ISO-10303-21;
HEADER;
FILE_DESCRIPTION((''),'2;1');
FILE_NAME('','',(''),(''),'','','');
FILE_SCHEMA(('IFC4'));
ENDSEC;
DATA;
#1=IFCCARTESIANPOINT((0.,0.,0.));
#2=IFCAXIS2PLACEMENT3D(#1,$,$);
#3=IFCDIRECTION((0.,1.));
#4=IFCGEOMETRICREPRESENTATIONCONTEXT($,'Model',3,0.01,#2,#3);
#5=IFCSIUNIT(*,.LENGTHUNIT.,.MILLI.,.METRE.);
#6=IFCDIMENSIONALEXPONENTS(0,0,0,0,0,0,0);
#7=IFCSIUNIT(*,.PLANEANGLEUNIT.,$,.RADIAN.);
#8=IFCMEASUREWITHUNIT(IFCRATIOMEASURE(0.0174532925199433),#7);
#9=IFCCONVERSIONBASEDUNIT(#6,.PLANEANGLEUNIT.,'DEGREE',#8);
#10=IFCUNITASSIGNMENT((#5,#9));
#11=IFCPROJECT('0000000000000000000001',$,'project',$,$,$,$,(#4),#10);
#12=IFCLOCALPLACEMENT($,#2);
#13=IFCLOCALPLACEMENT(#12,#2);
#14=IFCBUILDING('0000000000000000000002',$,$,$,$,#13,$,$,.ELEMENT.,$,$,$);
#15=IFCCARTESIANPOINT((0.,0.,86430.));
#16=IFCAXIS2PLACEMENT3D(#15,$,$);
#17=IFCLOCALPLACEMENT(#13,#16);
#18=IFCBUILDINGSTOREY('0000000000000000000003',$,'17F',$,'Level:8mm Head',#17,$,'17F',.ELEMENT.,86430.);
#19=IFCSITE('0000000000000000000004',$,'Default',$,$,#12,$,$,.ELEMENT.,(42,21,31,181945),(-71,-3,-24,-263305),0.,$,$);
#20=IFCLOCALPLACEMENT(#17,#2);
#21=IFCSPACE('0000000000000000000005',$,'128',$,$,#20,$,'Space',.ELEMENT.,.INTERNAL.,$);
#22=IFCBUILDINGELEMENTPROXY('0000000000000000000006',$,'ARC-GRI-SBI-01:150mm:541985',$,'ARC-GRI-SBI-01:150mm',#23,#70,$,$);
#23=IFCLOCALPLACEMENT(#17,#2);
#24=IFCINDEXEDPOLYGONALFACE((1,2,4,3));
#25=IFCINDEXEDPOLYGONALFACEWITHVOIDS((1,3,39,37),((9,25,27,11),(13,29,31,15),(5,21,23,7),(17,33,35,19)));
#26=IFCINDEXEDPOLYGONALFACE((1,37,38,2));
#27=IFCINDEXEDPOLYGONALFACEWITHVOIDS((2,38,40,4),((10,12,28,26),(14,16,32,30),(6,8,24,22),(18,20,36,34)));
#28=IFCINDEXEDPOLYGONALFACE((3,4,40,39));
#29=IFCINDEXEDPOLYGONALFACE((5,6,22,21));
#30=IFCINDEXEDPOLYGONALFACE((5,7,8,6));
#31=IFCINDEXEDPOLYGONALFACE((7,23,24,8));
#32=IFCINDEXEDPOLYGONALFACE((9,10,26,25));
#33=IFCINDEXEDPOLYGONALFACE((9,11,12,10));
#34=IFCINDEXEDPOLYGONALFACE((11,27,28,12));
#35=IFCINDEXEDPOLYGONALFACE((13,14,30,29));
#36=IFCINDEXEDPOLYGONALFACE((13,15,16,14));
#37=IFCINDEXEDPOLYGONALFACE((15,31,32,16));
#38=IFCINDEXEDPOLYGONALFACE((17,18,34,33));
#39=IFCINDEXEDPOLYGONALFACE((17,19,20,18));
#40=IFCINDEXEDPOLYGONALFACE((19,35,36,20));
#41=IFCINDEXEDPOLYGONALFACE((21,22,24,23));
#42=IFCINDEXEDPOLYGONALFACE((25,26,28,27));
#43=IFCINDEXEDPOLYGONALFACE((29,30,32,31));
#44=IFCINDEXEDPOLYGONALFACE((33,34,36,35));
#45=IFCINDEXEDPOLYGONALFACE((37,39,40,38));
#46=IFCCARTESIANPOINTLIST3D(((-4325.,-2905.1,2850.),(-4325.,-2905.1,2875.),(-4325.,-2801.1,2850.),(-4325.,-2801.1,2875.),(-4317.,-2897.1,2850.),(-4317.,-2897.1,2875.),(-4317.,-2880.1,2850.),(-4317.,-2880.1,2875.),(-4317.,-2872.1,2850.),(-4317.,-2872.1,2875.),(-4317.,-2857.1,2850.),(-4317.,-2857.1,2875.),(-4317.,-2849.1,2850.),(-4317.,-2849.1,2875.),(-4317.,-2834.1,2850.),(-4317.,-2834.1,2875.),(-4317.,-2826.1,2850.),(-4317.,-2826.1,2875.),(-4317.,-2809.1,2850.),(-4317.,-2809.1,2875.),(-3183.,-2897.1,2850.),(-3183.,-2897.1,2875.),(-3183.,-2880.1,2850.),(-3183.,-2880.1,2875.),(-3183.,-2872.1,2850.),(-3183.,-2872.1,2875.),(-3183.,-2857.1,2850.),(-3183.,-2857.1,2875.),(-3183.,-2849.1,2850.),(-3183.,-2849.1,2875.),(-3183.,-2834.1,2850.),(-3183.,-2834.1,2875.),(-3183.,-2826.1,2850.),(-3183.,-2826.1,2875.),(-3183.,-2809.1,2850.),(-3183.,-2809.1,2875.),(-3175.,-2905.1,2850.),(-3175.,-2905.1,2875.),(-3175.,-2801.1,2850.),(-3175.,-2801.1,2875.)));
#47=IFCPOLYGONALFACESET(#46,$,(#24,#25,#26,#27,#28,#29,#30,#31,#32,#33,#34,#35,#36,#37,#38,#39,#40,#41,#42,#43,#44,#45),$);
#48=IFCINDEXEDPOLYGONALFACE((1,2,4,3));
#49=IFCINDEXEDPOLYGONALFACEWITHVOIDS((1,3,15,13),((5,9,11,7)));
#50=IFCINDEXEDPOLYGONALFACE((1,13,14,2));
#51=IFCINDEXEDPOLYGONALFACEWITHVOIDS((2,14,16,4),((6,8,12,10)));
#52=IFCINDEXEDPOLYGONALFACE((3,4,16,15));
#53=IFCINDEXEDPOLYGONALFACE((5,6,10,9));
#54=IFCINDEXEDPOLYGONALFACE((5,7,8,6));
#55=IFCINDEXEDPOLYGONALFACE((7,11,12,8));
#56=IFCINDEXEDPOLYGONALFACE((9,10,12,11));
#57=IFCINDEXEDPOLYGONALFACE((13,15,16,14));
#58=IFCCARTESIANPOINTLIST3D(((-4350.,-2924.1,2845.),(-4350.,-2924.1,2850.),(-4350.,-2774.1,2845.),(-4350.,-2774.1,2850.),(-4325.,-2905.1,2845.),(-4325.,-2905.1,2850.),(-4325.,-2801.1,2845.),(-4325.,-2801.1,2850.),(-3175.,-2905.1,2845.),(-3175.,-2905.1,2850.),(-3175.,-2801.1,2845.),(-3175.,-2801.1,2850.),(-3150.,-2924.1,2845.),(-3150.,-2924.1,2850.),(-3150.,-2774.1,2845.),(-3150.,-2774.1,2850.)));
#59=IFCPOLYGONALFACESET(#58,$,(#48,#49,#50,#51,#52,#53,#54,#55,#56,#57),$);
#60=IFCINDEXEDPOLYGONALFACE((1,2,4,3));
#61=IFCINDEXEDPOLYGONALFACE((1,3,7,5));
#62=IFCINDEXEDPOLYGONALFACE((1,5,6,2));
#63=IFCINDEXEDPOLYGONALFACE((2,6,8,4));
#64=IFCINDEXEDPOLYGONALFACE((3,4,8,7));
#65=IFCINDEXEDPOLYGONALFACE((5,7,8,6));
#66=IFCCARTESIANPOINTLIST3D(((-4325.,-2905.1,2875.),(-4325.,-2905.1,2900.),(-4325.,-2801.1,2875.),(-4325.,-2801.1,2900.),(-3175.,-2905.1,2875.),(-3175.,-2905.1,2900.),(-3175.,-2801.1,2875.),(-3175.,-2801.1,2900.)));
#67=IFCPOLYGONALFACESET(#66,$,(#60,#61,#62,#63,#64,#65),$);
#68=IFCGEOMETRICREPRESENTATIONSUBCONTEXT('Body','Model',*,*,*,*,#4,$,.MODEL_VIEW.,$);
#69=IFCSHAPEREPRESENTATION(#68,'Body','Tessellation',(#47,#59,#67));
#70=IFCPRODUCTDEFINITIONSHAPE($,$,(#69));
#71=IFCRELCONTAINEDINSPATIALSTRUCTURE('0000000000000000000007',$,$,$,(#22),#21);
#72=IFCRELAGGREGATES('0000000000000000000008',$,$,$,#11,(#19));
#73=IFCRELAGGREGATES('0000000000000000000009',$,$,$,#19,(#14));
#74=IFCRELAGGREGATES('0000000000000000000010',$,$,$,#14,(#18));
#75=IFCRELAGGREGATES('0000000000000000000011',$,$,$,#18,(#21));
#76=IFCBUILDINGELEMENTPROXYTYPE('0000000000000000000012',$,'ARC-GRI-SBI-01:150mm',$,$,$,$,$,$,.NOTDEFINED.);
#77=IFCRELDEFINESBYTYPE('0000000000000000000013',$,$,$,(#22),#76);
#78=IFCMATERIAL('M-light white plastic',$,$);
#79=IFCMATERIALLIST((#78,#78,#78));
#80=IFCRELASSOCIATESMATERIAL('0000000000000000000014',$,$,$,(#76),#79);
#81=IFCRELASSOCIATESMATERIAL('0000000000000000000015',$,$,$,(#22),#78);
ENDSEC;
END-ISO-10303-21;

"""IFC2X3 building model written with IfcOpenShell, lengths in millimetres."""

from ifc_helpers import new_model, entity, si_unit, converted_unit, direction, frame, origin, origin_2d_with_axis, place, context, subcontext, project, spatial, polyline, rectangle, outline, extrude, source, transform, mapped, material, material_list, type_object, type_shapes, element, save


model = new_model("IFC2X3")

# Units and contexts
model_context = context("Model", 3, precision=0.01, world=origin(), true_north=direction((0.0, 1.0)))
body_context = subcontext(model_context, "Body", "Model", "MODEL_VIEW")
ifc_project = project(units=[si_unit("LENGTHUNIT", "METRE", prefix="MILLI"), converted_unit("PLANEANGLEUNIT", "DEGREE", entity("IfcRatioMeasure", 0.0174532925199433), si_unit("PLANEANGLEUNIT", "RADIAN"), dimensions=[0, 0, 0, 0, 0, 0, 0])], contexts=[model_context])

# Site, building, storey
site_placement = place(None, origin())
site = spatial("IfcSite", under=ifc_project, at=site_placement, Name="Default", CompositionType="ELEMENT", RefLatitude=(42, 21, 31, 181945), RefLongitude=(-71, -3, -24, -263305), RefElevation=0.0)
building_placement = place(site_placement, origin())
building = spatial("IfcBuilding", under=site, at=building_placement, CompositionType="ELEMENT")
storey_placement = place(building_placement, frame((0.0, 0.0, 86430.0)))
storey = spatial("IfcBuildingStorey", under=building, at=storey_placement, Name="17F", ObjectType="Level:8mm Head", LongName="17F", CompositionType="ELEMENT", Elevation=86430.0)

# Shared definitions
space_placement = place(storey_placement, origin())
space = spatial("IfcSpace", under=storey, at=space_placement, Name="128", LongName="Space", CompositionType="ELEMENT", InteriorOrExteriorSpace="INTERNAL")

# Building element proxy
ifc_material_1 = material(Name="M-light white plastic")
ifc_material_list = material_list([ifc_material_1, ifc_material_1, ifc_material_1])
building_element_proxy_type = type_object("IfcBuildingElementProxyType", Name="ARC-GRI-SBI-01:150mm", PredefinedType="NOTDEFINED", material=ifc_material_list)
shared_shape = source(origin(), body_context, "Body", "SweptSolid", [
    extrude(outline(polyline([(-575.0, -52.0), (575.0, -52.0), (575.0, 52.0), (-575.0, 52.0), (-575.0, -52.0)]), holes=[polyline([(-567.0, -44.0), (-567.0, -27.0), (567.0, -27.0), (567.0, -44.0), (-567.0, -44.0)]), polyline([(567.0, -4.0), (567.0, -19.0), (-567.0, -19.0), (-567.0, -4.0), (567.0, -4.0)]), polyline([(-567.0, 44.0), (567.0, 44.0), (567.0, 27.0), (-567.0, 27.0), (-567.0, 44.0)]), polyline([(567.0, 4.0), (-567.0, 4.0), (-567.0, 19.0), (567.0, 19.0), (567.0, 4.0)])]), frame((425.0, 4.0, 4000.0), z_axis=(0.0, 0.0, 1.0), x_axis=(-1.0, 0.0, 0.0)), (0.0, 0.0, 1.0), 25.0),
    extrude(outline(polyline([(-600.0, -75.0), (600.0, -75.0), (600.0, 75.0), (-600.0, 75.0), (-600.0, -75.0)]), holes=[polyline([(-575.0, -56.0), (-575.0, 48.0), (575.0, 48.0), (575.0, -56.0), (-575.0, -56.0)])]), frame((425.0, 0.0, 3995.0), z_axis=(0.0, 0.0, 1.0), x_axis=(-1.0, 0.0, 0.0)), (0.0, 0.0, 1.0), 5.0),
    extrude(rectangle(XDim=1150.0, YDim=104.0, at=origin_2d_with_axis()), frame((425.0, 4.0, 4025.0), z_axis=(0.0, 0.0, 1.0), x_axis=(-1.0, 0.0, 0.0)), (0.0, 0.0, 1.0), 25.0),
])
type_shapes(building_element_proxy_type, [shared_shape])
for number, where, z_axis, x_axis, name in (
    (1, (-3325.0, -2849.1, -1150.0), (0.0, 0.0, 1.0), (-1.0, 0.0, 0.0), "ARC-GRI-SBI-01:150mm:541985"),
):
    element("IfcBuildingElementProxy", number, at=place(space_placement, frame(where, z_axis=z_axis, x_axis=x_axis)), inside=space, type_object=building_element_proxy_type, material=ifc_material_1, Name=name, ObjectType="ARC-GRI-SBI-01:150mm", context=body_context, shape_type="MappedRepresentation", body=[
        mapped(shared_shape, transform((0.0, 0.0, 0.0), scale=1.0)),
    ])

save(model, "model.ifc")
